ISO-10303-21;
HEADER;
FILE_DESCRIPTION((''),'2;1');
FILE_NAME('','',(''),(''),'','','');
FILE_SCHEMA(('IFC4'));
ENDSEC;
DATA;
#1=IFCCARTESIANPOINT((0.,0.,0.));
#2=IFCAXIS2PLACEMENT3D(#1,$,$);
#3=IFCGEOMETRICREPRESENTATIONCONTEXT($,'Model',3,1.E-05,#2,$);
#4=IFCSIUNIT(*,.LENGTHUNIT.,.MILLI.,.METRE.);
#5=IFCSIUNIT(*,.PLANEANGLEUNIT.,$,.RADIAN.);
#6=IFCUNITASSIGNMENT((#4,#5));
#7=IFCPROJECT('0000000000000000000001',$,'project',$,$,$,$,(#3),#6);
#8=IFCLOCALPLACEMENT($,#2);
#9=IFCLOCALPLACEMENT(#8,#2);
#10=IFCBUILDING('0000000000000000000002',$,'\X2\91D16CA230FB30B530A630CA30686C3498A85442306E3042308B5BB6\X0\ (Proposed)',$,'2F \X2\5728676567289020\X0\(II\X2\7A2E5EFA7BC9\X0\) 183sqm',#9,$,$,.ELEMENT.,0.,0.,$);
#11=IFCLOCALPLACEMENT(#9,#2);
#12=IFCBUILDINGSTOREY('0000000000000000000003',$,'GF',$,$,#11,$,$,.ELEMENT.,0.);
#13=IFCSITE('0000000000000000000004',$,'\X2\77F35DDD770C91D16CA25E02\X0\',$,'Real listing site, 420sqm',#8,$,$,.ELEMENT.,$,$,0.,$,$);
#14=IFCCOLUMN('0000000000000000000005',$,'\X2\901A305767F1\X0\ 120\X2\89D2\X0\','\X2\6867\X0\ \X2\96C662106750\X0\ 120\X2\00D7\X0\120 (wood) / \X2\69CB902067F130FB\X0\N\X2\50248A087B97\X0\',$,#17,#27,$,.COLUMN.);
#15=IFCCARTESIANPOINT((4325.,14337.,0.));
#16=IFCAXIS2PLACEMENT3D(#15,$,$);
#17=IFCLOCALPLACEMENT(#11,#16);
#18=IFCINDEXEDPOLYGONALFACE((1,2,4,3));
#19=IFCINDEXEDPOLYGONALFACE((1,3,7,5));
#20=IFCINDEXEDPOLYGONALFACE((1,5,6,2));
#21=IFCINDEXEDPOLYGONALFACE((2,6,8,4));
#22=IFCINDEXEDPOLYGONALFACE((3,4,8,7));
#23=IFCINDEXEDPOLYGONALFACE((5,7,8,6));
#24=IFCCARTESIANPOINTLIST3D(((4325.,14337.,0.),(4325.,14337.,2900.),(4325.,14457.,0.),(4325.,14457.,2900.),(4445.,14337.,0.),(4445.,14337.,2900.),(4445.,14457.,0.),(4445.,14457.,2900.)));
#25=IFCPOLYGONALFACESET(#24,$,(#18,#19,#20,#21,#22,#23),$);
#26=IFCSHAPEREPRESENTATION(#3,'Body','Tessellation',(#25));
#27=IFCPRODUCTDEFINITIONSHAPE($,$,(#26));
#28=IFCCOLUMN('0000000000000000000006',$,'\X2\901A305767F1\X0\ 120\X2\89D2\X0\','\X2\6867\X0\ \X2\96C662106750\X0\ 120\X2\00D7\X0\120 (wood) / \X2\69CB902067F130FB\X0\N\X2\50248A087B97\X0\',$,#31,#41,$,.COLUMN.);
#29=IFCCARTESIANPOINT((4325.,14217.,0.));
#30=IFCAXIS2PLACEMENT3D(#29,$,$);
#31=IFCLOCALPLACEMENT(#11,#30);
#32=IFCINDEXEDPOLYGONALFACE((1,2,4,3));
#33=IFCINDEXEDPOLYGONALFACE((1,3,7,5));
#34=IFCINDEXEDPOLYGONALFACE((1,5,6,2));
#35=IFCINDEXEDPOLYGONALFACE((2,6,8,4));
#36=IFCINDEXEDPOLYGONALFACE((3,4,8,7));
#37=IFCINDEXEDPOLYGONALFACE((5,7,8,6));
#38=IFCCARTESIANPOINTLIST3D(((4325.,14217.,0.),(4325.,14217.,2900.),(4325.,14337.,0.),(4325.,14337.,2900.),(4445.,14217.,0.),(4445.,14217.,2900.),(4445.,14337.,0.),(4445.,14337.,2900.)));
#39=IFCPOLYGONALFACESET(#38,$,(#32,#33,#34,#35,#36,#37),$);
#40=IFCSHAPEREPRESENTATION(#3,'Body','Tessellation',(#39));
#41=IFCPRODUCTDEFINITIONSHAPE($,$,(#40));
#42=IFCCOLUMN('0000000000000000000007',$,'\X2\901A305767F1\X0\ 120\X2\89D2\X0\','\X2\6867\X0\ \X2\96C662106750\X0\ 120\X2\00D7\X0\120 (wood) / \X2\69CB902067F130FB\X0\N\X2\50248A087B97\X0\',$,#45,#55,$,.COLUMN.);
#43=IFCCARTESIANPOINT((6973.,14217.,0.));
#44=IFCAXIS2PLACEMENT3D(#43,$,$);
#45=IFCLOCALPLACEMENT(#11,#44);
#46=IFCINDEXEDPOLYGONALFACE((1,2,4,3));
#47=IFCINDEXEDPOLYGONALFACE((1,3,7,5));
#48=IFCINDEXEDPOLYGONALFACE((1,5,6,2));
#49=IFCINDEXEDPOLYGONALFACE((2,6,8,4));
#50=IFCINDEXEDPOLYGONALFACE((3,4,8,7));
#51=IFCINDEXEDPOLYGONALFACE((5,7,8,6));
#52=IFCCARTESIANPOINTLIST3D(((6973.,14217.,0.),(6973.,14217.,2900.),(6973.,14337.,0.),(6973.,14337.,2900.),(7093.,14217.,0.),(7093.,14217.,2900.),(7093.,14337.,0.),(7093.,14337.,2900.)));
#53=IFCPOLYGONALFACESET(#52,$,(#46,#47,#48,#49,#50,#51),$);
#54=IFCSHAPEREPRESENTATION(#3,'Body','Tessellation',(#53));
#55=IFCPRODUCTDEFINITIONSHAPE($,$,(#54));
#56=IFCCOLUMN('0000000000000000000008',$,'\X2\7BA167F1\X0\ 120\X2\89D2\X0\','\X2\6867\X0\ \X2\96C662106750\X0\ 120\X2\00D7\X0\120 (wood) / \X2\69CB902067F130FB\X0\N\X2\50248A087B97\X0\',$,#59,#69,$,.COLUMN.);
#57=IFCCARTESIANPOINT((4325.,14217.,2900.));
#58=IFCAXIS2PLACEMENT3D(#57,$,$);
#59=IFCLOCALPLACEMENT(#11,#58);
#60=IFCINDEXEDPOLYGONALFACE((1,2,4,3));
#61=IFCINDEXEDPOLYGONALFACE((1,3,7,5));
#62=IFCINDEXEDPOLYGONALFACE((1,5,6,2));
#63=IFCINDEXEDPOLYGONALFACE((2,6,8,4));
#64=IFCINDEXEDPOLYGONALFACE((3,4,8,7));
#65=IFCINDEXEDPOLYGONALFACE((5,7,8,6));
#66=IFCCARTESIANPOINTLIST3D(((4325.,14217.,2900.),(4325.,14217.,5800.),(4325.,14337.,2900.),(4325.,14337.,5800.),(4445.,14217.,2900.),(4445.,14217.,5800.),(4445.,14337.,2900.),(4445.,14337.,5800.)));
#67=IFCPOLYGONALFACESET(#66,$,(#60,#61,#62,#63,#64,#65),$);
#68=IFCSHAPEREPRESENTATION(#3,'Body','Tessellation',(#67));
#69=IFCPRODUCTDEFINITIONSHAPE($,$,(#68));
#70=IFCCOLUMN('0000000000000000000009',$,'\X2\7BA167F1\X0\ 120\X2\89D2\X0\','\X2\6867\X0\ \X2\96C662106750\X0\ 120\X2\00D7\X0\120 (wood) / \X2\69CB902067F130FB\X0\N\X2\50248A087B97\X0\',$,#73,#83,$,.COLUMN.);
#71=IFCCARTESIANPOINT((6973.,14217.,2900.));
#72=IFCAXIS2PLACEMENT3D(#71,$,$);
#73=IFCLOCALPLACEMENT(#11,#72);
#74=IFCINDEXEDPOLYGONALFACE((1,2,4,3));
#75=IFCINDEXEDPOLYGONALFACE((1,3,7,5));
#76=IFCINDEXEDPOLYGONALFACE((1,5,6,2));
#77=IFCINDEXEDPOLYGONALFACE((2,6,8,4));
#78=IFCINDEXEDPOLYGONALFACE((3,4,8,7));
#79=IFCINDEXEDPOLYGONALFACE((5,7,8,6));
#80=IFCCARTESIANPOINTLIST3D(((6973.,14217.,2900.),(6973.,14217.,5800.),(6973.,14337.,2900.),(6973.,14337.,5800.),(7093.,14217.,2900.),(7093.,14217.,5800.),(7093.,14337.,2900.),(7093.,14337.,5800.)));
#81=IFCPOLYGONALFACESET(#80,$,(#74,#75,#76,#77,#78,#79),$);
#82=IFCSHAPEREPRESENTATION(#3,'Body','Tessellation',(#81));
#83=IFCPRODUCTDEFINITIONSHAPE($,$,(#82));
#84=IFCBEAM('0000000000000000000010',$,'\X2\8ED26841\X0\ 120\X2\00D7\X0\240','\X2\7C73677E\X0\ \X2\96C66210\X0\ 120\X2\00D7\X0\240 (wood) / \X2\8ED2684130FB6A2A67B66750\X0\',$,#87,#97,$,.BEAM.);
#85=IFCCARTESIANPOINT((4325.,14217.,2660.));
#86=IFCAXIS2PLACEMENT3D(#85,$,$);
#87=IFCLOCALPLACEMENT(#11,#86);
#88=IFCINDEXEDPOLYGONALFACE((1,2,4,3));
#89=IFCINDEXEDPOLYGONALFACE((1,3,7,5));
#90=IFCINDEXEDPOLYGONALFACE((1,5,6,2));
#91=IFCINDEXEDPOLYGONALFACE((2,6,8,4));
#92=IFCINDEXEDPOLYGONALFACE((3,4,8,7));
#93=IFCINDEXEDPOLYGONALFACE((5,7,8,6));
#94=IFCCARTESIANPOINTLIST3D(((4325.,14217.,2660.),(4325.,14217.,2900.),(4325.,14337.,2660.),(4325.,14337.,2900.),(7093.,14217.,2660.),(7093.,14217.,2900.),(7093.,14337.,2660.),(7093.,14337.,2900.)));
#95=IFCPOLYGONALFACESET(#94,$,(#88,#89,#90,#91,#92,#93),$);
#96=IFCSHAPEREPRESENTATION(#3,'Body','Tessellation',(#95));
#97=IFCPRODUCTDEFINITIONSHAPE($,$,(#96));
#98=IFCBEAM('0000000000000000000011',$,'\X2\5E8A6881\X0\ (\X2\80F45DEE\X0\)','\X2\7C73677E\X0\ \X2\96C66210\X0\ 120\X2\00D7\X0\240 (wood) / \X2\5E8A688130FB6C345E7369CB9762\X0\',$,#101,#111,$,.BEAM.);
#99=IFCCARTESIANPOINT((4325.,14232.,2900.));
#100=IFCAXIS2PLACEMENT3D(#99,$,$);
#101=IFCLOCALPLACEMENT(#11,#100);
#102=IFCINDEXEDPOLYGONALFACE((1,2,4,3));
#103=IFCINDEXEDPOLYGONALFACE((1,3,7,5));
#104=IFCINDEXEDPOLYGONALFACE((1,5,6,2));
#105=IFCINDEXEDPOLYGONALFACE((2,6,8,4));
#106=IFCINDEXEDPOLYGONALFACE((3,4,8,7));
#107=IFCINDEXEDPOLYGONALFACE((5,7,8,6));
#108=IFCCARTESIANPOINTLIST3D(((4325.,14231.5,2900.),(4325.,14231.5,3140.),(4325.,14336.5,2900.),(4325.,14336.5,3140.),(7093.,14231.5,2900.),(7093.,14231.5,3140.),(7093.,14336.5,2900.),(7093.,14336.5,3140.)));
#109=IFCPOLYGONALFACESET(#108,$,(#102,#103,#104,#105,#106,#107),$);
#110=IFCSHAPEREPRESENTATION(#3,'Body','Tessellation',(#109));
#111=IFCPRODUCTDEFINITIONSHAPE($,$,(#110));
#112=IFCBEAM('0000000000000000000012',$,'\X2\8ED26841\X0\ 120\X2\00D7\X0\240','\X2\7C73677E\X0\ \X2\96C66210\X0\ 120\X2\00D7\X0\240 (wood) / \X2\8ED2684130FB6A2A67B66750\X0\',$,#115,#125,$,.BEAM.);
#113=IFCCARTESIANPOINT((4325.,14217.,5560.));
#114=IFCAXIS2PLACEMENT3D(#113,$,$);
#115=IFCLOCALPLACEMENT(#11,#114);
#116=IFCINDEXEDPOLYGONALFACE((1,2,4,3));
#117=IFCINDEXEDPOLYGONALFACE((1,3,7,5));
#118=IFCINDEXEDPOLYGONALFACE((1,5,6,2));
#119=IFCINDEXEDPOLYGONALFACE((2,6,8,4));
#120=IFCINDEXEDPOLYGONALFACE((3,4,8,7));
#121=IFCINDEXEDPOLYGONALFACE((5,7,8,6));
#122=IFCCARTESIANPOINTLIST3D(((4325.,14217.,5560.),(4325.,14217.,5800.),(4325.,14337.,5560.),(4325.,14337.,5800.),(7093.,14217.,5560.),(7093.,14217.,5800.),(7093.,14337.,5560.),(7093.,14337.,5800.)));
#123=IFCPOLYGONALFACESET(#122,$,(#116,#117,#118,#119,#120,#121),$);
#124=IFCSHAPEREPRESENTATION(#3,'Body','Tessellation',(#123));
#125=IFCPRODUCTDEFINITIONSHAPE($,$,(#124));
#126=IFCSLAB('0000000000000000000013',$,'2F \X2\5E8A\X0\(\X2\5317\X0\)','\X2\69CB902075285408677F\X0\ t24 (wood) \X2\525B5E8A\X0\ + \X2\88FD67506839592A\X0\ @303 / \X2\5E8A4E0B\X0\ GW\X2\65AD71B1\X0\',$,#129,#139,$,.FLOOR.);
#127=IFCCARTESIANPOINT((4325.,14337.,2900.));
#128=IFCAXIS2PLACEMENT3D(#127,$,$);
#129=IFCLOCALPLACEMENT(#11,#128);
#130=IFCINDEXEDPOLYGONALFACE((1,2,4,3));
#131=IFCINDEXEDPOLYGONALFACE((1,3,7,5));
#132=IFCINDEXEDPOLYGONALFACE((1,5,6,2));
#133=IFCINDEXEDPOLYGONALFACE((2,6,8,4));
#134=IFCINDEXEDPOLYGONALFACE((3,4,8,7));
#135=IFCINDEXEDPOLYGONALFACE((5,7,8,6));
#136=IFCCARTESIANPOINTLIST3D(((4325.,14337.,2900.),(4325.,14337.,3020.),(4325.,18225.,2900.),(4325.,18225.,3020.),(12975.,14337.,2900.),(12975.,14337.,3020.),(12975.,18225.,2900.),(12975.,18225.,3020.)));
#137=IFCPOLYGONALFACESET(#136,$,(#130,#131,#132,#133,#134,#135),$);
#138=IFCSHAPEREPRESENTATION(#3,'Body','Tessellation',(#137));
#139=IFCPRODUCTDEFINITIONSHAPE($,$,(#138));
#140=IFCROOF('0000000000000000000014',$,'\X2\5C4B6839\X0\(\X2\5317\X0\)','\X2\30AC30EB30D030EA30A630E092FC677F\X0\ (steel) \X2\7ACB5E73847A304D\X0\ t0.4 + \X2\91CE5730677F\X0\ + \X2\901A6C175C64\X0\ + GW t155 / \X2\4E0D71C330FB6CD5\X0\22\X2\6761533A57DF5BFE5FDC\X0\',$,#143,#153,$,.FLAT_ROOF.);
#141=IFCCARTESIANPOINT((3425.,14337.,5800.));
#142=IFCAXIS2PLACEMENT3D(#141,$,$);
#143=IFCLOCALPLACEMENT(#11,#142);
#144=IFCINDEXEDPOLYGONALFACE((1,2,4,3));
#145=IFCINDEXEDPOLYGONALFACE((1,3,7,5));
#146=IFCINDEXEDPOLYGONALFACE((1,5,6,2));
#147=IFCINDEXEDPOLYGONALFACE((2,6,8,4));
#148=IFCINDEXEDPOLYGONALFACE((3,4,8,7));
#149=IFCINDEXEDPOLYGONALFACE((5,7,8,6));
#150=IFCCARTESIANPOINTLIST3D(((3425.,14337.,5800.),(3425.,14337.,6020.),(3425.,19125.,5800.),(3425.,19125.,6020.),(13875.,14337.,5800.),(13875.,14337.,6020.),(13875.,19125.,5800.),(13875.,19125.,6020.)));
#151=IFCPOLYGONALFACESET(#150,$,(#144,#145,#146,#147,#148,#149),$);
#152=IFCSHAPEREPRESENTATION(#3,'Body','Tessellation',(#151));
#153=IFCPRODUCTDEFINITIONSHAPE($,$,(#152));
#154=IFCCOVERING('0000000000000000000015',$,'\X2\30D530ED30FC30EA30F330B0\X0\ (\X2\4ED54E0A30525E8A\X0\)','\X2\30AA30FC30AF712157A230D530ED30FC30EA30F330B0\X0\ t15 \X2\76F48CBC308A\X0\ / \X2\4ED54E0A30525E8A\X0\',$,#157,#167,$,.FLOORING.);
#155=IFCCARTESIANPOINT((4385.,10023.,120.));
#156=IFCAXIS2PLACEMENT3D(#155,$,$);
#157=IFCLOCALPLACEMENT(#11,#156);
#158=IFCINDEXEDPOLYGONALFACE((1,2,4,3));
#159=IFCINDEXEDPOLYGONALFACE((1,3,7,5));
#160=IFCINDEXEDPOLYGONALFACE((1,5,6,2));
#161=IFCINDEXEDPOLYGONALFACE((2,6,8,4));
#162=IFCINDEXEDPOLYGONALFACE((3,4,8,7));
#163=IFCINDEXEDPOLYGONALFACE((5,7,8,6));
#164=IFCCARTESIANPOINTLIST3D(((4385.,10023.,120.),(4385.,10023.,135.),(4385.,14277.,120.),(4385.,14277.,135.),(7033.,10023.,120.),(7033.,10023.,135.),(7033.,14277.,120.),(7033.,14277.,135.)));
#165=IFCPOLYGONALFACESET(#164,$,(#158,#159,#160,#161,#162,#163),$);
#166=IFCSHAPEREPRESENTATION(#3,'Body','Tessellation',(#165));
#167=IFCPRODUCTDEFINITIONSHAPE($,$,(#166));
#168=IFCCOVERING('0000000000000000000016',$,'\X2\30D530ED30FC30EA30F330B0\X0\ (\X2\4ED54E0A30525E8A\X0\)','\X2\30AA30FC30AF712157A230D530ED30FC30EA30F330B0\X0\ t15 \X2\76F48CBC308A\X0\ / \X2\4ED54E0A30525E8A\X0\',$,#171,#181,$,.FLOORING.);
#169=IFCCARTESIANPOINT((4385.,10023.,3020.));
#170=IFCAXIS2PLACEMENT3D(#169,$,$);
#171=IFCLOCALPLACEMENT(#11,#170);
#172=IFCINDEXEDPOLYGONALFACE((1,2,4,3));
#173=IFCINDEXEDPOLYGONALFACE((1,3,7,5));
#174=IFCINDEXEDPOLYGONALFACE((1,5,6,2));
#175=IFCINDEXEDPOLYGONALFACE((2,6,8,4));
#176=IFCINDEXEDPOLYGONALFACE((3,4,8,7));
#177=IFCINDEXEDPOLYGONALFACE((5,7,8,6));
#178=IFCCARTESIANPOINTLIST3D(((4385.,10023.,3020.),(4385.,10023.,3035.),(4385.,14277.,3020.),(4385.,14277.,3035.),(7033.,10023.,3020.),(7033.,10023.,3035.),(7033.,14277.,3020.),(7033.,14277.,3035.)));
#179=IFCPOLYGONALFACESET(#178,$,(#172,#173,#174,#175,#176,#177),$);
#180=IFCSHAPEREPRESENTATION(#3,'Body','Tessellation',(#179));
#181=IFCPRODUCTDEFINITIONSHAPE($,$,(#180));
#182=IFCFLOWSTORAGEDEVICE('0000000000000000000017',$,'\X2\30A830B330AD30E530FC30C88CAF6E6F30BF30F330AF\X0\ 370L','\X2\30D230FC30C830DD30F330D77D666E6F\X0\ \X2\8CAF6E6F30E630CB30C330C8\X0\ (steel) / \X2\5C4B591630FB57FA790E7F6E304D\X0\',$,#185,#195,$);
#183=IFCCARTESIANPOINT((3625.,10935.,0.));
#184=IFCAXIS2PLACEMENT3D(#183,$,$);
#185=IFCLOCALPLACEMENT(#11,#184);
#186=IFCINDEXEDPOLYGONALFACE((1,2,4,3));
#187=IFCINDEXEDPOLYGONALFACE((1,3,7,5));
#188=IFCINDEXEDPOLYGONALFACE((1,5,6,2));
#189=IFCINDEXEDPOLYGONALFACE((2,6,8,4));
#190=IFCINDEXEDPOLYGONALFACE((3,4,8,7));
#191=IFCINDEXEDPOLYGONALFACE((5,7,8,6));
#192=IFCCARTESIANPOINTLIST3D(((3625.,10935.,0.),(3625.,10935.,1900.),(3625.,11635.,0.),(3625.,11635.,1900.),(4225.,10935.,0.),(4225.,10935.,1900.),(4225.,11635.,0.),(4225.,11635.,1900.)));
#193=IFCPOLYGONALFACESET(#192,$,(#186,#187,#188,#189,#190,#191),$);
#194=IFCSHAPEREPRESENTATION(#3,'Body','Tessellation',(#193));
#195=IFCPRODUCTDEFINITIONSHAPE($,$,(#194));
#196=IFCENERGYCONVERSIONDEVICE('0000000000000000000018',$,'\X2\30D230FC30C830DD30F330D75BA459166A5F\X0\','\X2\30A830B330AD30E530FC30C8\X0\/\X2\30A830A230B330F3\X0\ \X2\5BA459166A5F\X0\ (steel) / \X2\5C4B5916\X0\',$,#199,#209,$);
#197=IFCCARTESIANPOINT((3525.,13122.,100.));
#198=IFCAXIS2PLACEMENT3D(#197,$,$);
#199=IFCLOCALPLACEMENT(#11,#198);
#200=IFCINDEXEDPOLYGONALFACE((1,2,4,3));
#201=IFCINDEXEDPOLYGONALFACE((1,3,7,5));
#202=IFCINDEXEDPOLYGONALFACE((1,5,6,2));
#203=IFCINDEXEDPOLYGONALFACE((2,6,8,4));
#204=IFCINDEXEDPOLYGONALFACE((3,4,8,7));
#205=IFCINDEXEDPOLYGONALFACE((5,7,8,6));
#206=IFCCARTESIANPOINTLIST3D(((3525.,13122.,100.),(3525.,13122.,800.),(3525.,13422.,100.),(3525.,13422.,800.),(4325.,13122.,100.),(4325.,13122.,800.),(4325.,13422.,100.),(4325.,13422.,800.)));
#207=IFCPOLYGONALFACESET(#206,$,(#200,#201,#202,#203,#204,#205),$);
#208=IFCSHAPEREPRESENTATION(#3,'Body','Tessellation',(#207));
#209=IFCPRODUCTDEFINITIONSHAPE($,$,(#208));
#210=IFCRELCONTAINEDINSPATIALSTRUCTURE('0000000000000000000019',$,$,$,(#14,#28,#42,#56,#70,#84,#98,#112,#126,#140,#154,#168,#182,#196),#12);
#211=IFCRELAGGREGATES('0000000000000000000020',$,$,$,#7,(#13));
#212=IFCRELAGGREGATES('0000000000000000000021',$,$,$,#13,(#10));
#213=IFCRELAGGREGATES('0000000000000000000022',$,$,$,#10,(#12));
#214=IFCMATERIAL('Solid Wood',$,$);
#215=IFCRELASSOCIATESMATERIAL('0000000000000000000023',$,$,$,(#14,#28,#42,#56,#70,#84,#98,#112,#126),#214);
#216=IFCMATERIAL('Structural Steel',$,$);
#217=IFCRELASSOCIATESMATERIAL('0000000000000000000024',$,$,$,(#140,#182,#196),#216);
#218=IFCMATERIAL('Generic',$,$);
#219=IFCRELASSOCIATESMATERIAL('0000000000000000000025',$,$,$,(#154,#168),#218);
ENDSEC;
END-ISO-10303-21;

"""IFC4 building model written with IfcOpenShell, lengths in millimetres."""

from ifc_helpers import new_model, si_unit, frame, frame_2d, origin, place, context, project, spatial, rectangle, extrude, material, element, save


model = new_model("IFC4")

# Units and contexts
model_context = context("Model", 3, precision=1e-05, world=origin())
ifc_project = project(units=[si_unit("LENGTHUNIT", "METRE", prefix="MILLI"), si_unit("PLANEANGLEUNIT", "RADIAN")], contexts=[model_context])

# Site, building, storey
site_placement = place(None, origin())
site = spatial("IfcSite", under=ifc_project, at=site_placement, Name="石川県金沢市", ObjectType="Real listing site, 420sqm", CompositionType="ELEMENT", RefElevation=0.0)
building_placement = place(site_placement, origin())
building = spatial("IfcBuilding", under=site, at=building_placement, Name="金沢・サウナと水風呂のある家 (Proposed)", ObjectType="2F 在来木造(II種建築) 183sqm", CompositionType="ELEMENT", ElevationOfRefHeight=0.0, ElevationOfTerrain=0.0)
storey_placement = place(building_placement, origin())
storey = spatial("IfcBuildingStorey", under=building, at=storey_placement, Name="GF", CompositionType="ELEMENT", Elevation=0.0)

# Columns
ifc_material_1 = material(Name="Solid Wood")
column_1_placement = place(storey_placement, frame((4325.0, 14337.0, 0.0)))
element("IfcColumn", 1, at=column_1_placement, inside=storey, material=ifc_material_1, Name="通し柱 120角", Description="桧 集成材 120×120 (wood) / 構造柱・N値計算", PredefinedType="COLUMN", context=model_context, shape_type="SweptSolid", body=[
    extrude(rectangle(XDim=120.0, YDim=120.0, at=frame_2d((60.0, 60.0))), frame((4325.0, 14337.0, 0.0)), (0.0, 0.0, 1.0), 2900.0),
])
column_2_placement = place(storey_placement, frame((4325.0, 14217.0, 0.0)))
element("IfcColumn", 2, at=column_2_placement, inside=storey, material=ifc_material_1, Name="通し柱 120角", Description="桧 集成材 120×120 (wood) / 構造柱・N値計算", PredefinedType="COLUMN", context=model_context, shape_type="SweptSolid", body=[
    extrude(rectangle(XDim=120.0, YDim=120.0, at=frame_2d((60.0, 60.0))), frame((4325.0, 14217.0, 0.0)), (0.0, 0.0, 1.0), 2900.0),
])
column_3_placement = place(storey_placement, frame((6973.0, 14217.0, 0.0)))
element("IfcColumn", 3, at=column_3_placement, inside=storey, material=ifc_material_1, Name="通し柱 120角", Description="桧 集成材 120×120 (wood) / 構造柱・N値計算", PredefinedType="COLUMN", context=model_context, shape_type="SweptSolid", body=[
    extrude(rectangle(XDim=120.0, YDim=120.0, at=frame_2d((60.0, 60.0))), frame((6973.0, 14217.0, 0.0)), (0.0, 0.0, 1.0), 2900.0),
])
column_4_placement = place(storey_placement, frame((4325.0, 14217.0, 2900.0)))
element("IfcColumn", 4, at=column_4_placement, inside=storey, material=ifc_material_1, Name="管柱 120角", Description="桧 集成材 120×120 (wood) / 構造柱・N値計算", PredefinedType="COLUMN", context=model_context, shape_type="SweptSolid", body=[
    extrude(rectangle(XDim=120.0, YDim=120.0, at=frame_2d((60.0, 60.0))), frame((4325.0, 14217.0, 2900.0)), (0.0, 0.0, 1.0), 2900.0),
])
column_5_placement = place(storey_placement, frame((6973.0, 14217.0, 2900.0)))
element("IfcColumn", 5, at=column_5_placement, inside=storey, material=ifc_material_1, Name="管柱 120角", Description="桧 集成材 120×120 (wood) / 構造柱・N値計算", PredefinedType="COLUMN", context=model_context, shape_type="SweptSolid", body=[
    extrude(rectangle(XDim=120.0, YDim=120.0, at=frame_2d((60.0, 60.0))), frame((6973.0, 14217.0, 2900.0)), (0.0, 0.0, 1.0), 2900.0),
])

# Beams
beam_1_placement = place(storey_placement, frame((4325.0, 14217.0, 2660.0)))
element("IfcBeam", 6, at=beam_1_placement, inside=storey, material=ifc_material_1, Name="軒桁 120×240", Description="米松 集成 120×240 (wood) / 軒桁・横架材", PredefinedType="BEAM", context=model_context, shape_type="SweptSolid", body=[
    extrude(rectangle(XDim=2768.0, YDim=120.0, at=frame_2d((1384.0, 60.0))), frame((4325.0, 14217.0, 2660.0)), (0.0, 0.0, 1.0), 240.0),
])
beam_2_placement = place(storey_placement, frame((4325.0, 14232.0, 2900.0)))
element("IfcBeam", 7, at=beam_2_placement, inside=storey, material=ifc_material_1, Name="床梁 (胴差)", Description="米松 集成 120×240 (wood) / 床梁・水平構面", PredefinedType="BEAM", context=model_context, shape_type="SweptSolid", body=[
    extrude(rectangle(XDim=2768.0, YDim=105.0, at=frame_2d((1384.0, 52.0))), frame((4325.0, 14232.0, 2900.0)), (0.0, 0.0, 1.0), 240.0),
])
beam_3_placement = place(storey_placement, frame((4325.0, 14217.0, 5560.0)))
element("IfcBeam", 8, at=beam_3_placement, inside=storey, material=ifc_material_1, Name="軒桁 120×240", Description="米松 集成 120×240 (wood) / 軒桁・横架材", PredefinedType="BEAM", context=model_context, shape_type="SweptSolid", body=[
    extrude(rectangle(XDim=2768.0, YDim=120.0, at=frame_2d((1384.0, 60.0))), frame((4325.0, 14217.0, 5560.0)), (0.0, 0.0, 1.0), 240.0),
])

# Slab
slab_1_placement = place(storey_placement, frame((4325.0, 14337.0, 2900.0)))
element("IfcSlab", 9, at=slab_1_placement, inside=storey, material=ifc_material_1, Name="2F 床(北)", Description="構造用合板 t24 (wood) 剛床 + 製材根太 @303 / 床下 GW断熱", PredefinedType="FLOOR", context=model_context, shape_type="SweptSolid", body=[
    extrude(rectangle(XDim=8650.0, YDim=3888.0, at=frame_2d((4325.0, 1944.0))), frame((4325.0, 14337.0, 2900.0)), (0.0, 0.0, 1.0), 120.0),
])

# Roof
ifc_material_2 = material(Name="Structural Steel")
for number, where, name in (
    (10, (3425.0, 14337.0, 5800.0), "屋根(北)"),
):
    element("IfcRoof", number, at=place(storey_placement, frame(where)), inside=storey, material=ifc_material_2, Name=name, Description="ガルバリウム鋼板 (steel) 立平葺き t0.4 + 野地板 + 通気層 + GW t155 / 不燃・法22条区域対応", PredefinedType="FLAT_ROOF", context=model_context, shape_type="SweptSolid", body=[
        extrude(rectangle(XDim=10450.0, YDim=4788.0, at=frame_2d((5225.0, 2394.0))), frame((3425.0, 14337.0, 5800.0)), (0.0, 0.0, 1.0), 220.0),
    ])

# Coverings
ifc_material_3 = material(Name="Generic")
covering_1_placement = place(storey_placement, frame((4385.0, 10023.0, 120.0)))
element("IfcCovering", 11, at=covering_1_placement, inside=storey, material=ifc_material_3, Name="フローリング (仕上げ床)", Description="オーク無垢フローリング t15 直貼り / 仕上げ床", PredefinedType="FLOORING", context=model_context, shape_type="SweptSolid", body=[
    extrude(rectangle(XDim=2648.0, YDim=4254.0, at=frame_2d((1324.0, 2127.0))), frame((4385.0, 10023.0, 120.0)), (0.0, 0.0, 1.0), 15.0),
])
covering_2_placement = place(storey_placement, frame((4385.0, 10023.0, 3020.0)))
element("IfcCovering", 12, at=covering_2_placement, inside=storey, material=ifc_material_3, Name="フローリング (仕上げ床)", Description="オーク無垢フローリング t15 直貼り / 仕上げ床", PredefinedType="FLOORING", context=model_context, shape_type="SweptSolid", body=[
    extrude(rectangle(XDim=2648.0, YDim=4254.0, at=frame_2d((1324.0, 2127.0))), frame((4385.0, 10023.0, 3020.0)), (0.0, 0.0, 1.0), 15.0),
])

# Flow storage device
flow_storage_device_placement = place(storey_placement, frame((3625.0, 10935.0, 0.0)))
element("IfcFlowStorageDevice", 13, at=flow_storage_device_placement, inside=storey, material=ifc_material_2, Name="エコキュート貯湯タンク 370L", Description="ヒートポンプ給湯 貯湯ユニット (steel) / 屋外・基礎置き", context=model_context, shape_type="SweptSolid", body=[
    extrude(rectangle(XDim=600.0, YDim=700.0, at=frame_2d((300.0, 350.0))), frame((3625.0, 10935.0, 0.0)), (0.0, 0.0, 1.0), 1900.0),
])

# Energy conversion device
energy_conversion_device_placement = place(storey_placement, frame((3525.0, 13122.0, 100.0)))
element("IfcEnergyConversionDevice", 14, at=energy_conversion_device_placement, inside=storey, material=ifc_material_2, Name="ヒートポンプ室外機", Description="エコキュート/エアコン 室外機 (steel) / 屋外", context=model_context, shape_type="SweptSolid", body=[
    extrude(rectangle(XDim=800.0, YDim=300.0, at=frame_2d((400.0, 150.0))), frame((3525.0, 13122.0, 100.0)), (0.0, 0.0, 1.0), 700.0),
])

save(model, "model.ifc")
